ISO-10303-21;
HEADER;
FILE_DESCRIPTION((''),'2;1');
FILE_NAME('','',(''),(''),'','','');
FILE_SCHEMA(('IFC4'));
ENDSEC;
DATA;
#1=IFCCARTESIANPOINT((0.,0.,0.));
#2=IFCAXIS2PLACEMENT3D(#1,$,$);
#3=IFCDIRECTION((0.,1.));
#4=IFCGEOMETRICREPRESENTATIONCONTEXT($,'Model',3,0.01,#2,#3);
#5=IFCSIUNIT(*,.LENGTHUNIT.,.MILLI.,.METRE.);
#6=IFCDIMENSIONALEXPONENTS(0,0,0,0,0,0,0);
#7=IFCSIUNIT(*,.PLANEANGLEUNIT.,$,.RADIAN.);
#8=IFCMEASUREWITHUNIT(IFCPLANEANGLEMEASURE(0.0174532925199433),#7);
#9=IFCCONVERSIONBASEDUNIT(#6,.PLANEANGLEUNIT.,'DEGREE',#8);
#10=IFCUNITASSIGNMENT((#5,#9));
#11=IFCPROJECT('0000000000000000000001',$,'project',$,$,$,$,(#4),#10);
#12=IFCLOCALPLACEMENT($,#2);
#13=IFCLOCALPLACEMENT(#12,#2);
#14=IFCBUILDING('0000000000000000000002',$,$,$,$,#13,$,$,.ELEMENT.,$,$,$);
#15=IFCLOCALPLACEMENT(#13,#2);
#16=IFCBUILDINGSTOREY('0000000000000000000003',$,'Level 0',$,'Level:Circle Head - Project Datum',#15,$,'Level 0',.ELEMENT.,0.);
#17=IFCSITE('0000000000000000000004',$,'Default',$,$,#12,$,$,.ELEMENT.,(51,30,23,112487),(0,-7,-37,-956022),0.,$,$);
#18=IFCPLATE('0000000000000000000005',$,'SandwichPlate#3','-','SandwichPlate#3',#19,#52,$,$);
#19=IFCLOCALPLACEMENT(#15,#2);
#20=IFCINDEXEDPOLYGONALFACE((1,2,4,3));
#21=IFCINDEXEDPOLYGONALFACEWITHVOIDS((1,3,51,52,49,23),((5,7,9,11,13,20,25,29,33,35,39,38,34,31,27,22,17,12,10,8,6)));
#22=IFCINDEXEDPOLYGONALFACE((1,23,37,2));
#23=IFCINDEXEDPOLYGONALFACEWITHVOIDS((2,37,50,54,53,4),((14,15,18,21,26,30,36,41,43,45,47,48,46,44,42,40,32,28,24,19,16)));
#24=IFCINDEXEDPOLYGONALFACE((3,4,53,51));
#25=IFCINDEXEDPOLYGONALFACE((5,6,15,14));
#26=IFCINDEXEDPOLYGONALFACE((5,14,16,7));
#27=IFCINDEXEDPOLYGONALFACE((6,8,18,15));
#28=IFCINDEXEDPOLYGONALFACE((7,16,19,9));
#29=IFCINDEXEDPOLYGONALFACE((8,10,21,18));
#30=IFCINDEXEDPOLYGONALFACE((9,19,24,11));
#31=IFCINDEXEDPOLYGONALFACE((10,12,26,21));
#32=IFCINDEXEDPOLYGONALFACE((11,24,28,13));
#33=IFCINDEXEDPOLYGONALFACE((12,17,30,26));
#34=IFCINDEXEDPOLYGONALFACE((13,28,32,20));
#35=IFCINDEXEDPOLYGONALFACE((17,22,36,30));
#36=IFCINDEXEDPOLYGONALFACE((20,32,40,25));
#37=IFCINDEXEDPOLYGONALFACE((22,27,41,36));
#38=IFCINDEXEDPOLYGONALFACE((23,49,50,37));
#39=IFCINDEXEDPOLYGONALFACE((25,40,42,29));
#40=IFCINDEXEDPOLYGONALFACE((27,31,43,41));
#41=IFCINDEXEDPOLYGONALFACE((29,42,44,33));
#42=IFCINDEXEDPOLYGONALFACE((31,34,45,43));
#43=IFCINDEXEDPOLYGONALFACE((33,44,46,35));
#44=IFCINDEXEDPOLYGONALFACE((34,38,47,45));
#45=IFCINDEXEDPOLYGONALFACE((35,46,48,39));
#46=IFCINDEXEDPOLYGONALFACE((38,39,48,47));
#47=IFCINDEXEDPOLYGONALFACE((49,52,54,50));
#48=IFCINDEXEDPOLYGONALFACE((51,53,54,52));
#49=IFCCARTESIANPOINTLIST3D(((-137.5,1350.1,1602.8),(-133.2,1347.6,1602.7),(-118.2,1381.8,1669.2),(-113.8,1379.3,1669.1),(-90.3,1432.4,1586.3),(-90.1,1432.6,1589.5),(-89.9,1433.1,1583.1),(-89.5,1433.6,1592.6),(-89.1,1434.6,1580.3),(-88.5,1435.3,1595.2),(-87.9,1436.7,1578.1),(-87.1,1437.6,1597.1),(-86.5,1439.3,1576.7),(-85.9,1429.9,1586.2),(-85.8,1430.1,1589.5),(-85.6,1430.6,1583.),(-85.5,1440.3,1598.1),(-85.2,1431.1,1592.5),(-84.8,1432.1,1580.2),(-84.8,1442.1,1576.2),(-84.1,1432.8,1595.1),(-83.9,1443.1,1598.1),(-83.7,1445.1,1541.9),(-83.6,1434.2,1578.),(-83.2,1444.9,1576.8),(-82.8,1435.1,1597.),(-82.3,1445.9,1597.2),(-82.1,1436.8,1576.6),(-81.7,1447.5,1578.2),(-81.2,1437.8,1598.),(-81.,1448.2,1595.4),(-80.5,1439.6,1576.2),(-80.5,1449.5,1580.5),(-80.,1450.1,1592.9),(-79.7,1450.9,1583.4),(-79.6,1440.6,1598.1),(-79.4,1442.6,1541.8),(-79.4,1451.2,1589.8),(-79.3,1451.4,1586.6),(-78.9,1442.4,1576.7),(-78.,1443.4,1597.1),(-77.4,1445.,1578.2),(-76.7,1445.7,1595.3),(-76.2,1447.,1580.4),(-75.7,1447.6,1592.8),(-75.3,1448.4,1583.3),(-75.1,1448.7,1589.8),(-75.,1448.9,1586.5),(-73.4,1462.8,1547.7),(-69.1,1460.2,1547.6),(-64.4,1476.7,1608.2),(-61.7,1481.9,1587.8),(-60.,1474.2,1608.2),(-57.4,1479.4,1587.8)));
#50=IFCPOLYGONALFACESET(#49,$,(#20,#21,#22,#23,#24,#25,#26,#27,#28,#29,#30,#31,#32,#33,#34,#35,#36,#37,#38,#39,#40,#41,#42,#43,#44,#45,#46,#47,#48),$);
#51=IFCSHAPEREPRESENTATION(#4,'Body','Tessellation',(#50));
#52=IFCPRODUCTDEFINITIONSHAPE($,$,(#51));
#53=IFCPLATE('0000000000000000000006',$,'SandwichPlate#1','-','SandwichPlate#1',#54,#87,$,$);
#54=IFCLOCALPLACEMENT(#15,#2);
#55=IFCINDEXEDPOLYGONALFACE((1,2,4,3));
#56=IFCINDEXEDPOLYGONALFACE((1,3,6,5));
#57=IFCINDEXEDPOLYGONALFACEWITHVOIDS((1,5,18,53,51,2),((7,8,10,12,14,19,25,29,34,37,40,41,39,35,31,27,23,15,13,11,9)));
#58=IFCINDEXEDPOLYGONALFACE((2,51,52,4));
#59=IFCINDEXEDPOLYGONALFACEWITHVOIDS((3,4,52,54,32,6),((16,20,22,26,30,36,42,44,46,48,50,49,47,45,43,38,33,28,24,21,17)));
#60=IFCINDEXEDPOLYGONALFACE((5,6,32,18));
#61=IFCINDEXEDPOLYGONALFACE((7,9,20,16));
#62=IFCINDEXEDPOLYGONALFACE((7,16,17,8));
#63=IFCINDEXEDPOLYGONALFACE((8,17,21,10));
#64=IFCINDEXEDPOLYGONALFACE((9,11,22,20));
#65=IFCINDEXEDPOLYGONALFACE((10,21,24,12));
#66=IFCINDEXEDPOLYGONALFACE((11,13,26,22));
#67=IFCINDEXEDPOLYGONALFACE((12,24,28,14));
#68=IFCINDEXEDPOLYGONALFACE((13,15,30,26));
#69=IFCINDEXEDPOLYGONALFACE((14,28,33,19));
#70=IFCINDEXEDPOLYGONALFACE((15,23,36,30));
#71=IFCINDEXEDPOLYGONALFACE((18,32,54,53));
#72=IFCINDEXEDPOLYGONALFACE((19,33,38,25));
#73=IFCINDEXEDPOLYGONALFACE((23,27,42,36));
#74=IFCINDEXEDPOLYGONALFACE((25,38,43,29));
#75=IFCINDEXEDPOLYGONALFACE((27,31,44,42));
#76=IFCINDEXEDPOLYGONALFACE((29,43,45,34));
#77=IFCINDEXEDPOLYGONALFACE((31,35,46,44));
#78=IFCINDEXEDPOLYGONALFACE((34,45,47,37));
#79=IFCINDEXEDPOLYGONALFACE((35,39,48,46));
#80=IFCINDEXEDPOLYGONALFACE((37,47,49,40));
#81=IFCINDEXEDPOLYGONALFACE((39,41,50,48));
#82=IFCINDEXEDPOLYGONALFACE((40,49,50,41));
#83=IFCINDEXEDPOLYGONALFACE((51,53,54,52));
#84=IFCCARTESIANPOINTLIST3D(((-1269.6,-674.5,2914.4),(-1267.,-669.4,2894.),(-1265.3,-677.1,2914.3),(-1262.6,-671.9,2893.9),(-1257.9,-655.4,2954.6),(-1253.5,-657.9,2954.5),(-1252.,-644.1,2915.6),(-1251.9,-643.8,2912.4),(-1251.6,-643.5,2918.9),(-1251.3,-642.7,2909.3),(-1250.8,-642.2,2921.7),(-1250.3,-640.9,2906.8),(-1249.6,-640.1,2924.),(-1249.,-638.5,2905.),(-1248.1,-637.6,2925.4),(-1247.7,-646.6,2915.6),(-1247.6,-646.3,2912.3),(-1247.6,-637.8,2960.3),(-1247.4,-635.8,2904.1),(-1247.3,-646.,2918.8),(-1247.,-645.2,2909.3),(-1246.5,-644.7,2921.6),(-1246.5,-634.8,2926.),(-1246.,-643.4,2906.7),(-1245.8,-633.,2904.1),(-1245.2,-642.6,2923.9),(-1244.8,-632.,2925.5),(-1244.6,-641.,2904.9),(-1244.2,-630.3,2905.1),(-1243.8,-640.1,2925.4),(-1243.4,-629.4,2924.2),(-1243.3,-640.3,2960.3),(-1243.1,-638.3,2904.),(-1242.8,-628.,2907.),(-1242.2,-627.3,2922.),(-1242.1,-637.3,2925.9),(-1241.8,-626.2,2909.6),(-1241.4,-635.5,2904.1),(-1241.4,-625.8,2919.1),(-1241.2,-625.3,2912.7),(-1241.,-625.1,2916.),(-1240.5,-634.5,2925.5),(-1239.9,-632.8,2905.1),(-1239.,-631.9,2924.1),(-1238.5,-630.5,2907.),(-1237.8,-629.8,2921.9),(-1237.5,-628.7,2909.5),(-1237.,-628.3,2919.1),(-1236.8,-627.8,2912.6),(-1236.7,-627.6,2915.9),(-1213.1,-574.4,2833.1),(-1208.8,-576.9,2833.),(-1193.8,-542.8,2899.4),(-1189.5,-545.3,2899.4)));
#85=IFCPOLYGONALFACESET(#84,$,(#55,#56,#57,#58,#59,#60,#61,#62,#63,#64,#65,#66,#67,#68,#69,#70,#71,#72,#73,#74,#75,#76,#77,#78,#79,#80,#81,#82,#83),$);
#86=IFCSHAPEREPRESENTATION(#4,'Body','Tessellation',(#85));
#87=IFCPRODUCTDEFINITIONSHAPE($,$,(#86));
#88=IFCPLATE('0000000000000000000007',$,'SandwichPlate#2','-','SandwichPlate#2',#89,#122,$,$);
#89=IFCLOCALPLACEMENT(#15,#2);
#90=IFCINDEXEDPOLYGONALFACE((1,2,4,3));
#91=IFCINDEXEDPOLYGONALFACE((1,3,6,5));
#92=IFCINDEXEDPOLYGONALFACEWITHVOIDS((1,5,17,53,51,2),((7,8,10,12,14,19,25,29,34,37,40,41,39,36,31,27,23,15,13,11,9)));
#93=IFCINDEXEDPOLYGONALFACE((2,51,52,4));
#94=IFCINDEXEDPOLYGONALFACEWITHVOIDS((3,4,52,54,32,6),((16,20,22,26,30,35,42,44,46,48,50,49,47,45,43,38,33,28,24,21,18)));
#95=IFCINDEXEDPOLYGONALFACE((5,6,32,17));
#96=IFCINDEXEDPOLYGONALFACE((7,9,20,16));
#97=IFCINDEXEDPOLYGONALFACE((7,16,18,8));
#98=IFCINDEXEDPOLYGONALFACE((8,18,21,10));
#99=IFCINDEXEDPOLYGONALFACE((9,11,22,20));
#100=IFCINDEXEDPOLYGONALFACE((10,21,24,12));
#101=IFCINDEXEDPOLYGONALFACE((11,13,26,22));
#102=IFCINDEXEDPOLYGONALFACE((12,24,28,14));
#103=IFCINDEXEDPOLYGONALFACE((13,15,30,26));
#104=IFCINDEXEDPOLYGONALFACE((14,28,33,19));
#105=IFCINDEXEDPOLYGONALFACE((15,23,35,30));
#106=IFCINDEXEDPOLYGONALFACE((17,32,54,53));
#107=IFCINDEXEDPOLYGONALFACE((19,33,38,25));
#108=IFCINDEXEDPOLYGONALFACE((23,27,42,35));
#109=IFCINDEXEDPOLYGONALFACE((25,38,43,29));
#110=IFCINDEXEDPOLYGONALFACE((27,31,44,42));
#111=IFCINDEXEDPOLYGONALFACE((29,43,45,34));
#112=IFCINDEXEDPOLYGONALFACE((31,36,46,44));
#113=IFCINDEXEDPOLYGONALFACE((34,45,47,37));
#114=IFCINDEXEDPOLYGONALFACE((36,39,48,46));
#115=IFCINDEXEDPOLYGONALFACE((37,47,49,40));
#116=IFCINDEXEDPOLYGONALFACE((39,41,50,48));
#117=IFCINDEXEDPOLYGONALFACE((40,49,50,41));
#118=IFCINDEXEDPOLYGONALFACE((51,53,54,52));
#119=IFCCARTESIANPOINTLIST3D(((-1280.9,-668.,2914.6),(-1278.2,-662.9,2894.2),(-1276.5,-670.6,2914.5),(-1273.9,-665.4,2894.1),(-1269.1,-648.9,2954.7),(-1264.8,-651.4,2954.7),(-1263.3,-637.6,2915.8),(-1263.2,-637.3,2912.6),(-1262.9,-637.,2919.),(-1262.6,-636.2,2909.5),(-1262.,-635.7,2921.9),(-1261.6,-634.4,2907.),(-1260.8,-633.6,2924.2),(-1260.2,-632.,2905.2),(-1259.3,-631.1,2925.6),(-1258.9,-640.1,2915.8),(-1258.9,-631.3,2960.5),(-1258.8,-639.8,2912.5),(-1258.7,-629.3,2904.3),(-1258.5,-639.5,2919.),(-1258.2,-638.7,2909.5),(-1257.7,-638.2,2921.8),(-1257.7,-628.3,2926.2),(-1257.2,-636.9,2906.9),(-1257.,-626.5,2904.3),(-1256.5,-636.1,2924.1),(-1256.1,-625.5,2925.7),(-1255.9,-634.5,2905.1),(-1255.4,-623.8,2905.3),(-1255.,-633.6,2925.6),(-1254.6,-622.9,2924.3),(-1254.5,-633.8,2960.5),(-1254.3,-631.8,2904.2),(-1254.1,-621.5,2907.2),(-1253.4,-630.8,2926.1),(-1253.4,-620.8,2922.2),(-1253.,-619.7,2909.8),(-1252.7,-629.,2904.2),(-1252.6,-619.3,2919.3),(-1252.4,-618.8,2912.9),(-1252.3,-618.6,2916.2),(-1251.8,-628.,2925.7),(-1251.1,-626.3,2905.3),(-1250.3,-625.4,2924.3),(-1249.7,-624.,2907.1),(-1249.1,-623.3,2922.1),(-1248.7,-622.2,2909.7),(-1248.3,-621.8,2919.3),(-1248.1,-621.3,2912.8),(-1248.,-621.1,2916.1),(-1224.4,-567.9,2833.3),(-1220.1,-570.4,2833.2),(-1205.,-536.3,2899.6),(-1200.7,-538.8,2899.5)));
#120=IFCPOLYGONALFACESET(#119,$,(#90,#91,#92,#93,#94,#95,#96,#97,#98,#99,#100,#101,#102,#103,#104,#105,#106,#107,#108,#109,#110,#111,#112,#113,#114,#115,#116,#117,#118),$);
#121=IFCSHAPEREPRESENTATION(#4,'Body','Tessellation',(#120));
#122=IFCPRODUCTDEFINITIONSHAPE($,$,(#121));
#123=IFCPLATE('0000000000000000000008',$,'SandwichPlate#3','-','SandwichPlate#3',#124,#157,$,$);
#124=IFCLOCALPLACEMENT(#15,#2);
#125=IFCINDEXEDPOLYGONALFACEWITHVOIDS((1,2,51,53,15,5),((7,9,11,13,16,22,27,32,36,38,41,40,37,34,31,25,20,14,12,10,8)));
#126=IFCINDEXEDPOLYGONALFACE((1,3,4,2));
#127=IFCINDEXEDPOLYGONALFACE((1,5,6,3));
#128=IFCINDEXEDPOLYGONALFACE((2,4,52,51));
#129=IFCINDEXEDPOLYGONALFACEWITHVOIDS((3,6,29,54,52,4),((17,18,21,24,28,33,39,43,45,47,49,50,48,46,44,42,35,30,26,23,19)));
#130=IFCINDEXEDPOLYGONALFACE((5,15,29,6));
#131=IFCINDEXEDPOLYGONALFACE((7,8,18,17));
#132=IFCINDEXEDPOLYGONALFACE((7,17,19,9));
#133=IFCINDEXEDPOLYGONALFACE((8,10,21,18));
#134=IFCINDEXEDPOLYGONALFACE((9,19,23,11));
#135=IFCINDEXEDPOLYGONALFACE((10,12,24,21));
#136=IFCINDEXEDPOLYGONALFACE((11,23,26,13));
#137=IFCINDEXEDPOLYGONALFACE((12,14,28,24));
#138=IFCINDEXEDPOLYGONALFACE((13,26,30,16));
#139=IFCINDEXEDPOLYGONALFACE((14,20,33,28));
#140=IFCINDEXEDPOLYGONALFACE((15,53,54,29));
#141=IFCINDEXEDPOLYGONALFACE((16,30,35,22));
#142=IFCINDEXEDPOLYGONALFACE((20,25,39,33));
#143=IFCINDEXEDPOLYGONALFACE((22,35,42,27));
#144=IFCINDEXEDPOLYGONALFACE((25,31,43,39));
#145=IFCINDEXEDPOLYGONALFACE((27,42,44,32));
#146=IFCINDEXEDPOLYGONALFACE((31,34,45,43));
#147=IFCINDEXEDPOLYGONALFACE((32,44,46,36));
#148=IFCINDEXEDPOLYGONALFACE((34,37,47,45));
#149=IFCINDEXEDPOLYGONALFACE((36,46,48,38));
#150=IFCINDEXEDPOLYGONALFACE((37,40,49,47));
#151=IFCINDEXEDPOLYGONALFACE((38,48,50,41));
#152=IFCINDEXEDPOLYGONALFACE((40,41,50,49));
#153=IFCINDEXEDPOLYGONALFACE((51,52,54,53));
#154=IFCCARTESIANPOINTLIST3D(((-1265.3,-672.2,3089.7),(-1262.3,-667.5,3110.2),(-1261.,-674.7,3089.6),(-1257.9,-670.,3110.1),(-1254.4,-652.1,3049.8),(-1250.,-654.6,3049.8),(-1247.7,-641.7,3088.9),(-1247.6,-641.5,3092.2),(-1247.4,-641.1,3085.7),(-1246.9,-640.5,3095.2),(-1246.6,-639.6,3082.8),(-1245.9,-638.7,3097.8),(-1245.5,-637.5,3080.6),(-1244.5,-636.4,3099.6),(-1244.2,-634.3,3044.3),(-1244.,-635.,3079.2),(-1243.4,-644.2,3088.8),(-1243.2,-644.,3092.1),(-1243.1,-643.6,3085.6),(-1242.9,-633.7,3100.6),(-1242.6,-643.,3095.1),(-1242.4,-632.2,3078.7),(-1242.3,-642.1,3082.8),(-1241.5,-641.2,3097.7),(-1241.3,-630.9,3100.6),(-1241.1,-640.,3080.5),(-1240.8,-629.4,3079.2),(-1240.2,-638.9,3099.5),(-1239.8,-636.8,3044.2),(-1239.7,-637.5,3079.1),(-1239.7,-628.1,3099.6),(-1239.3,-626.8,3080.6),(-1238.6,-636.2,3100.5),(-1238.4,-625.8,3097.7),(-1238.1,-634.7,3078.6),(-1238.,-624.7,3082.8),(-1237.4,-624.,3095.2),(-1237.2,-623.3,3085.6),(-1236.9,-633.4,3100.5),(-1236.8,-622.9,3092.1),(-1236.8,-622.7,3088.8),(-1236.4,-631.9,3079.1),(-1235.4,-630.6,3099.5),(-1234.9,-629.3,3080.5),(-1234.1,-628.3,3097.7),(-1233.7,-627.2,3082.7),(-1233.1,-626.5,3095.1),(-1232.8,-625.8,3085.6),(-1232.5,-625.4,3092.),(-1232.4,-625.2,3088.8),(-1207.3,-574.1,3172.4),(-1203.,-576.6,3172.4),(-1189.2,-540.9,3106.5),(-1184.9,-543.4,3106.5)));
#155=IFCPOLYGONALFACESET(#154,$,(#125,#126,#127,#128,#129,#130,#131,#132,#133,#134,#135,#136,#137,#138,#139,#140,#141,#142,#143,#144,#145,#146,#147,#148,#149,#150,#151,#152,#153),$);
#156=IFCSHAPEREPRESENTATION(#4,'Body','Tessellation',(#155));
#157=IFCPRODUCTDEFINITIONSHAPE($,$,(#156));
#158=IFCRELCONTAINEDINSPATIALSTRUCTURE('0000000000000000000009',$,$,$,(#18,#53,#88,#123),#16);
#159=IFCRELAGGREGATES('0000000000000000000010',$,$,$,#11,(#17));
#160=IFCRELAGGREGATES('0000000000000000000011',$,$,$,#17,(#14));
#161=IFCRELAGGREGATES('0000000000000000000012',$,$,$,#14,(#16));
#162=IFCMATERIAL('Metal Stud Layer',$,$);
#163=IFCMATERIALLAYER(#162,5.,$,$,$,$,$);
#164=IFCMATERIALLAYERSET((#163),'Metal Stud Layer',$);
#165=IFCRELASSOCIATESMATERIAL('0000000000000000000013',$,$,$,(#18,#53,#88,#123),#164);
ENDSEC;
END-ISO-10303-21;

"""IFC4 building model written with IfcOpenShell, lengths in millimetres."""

from ifc_helpers import new_model, entity, si_unit, converted_unit, direction, frame, origin, origin_with_axes, origin_2d_with_axis, place, context, project, spatial, polyline, circle, outline, extrude, material, layer, layer_set, element, save


model = new_model("IFC4")

# Units and contexts
model_context = context("Model", 3, precision=0.01, world=origin(), true_north=direction((0.0, 1.0)))
ifc_project = project(units=[si_unit("LENGTHUNIT", "METRE", prefix="MILLI"), converted_unit("PLANEANGLEUNIT", "DEGREE", entity("IfcPlaneAngleMeasure", 0.0174532925199433), si_unit("PLANEANGLEUNIT", "RADIAN"), dimensions=[0, 0, 0, 0, 0, 0, 0])], contexts=[model_context])

# Site, building, storey
site_placement = place(None, origin())
site = spatial("IfcSite", under=ifc_project, at=site_placement, Name="Default", CompositionType="ELEMENT", RefLatitude=(51, 30, 23, 112487), RefLongitude=(0, -7, -37, -956022), RefElevation=0.0)
building_placement = place(site_placement, origin())
building = spatial("IfcBuilding", under=site, at=building_placement, CompositionType="ELEMENT")
storey_placement = place(building_placement, origin())
storey = spatial("IfcBuildingStorey", under=building, at=storey_placement, Name="Level 0", ObjectType="Level:Circle Head - Project Datum", LongName="Level 0", CompositionType="ELEMENT", Elevation=0.0)

# Plates, openings
ifc_material = material(Name="Metal Stud Layer")
ifc_layer_1 = layer(ifc_material, 5.0)
ifc_layer_set_1 = layer_set([ifc_layer_1], Name="Metal Stud Layer")
plate_1_placement = place(storey_placement, frame((-77.2, 1456.5, 1534.6), z_axis=(0.865935, -0.499948, -0.014432), x_axis=(0.254617, 0.415806, 0.873084)))
plate_1 = element("IfcPlate", 1, at=plate_1_placement, inside=storey, material=ifc_layer_set_1, Name="SandwichPlate#3", Description="-", ObjectType="SandwichPlate#3", context=model_context, shape_type="SweptSolid", body=[
    extrude(outline(polyline([(0.0, 0.0), (76.0, 0.0), (76.0, 140.0), (0.0, 140.0), (0.0, 0.0)])), origin_with_axes(), (0.0, 0.0, 1.0), 5.0),
])
opening_1_placement = place(plate_1_placement, frame((0.0, 0.0, 0.0), z_axis=(0.0, 0.0, 1.0), x_axis=(1.0, 0.0, 0.0)))
element("IfcOpeningElement", 2, at=opening_1_placement, cuts=plate_1, ObjectType="Opening", context=model_context, shape_type="SweptSolid", body=[
    extrude(outline(polyline([(0.0, 0.0), (15.0, 0.0), (0.0, 15.0), (0.0, 0.0)])), origin(), (0.0, 0.0, 1.0), 5.0),
])
opening_2_placement = place(plate_1_placement, frame((0.0, 0.0, 0.0), z_axis=(0.0, 0.0, 1.0), x_axis=(1.0, 0.0, 0.0)))
element("IfcOpeningElement", 3, at=opening_2_placement, cuts=plate_1, ObjectType="Opening", context=model_context, shape_type="SweptSolid", body=[
    extrude(outline(polyline([(76.0, 0.0), (76.0, 15.0), (61.0, 0.0), (76.0, 0.0)])), origin(), (0.0, 0.0, 1.0), 5.0),
])
opening_3_placement = place(plate_1_placement, frame((38.0, 40.0, -0.5), z_axis=(0.0, 0.0, 1.0), x_axis=(0.0, 1.0, 0.0)))
element("IfcOpeningElement", 4, at=opening_3_placement, cuts=plate_1, ObjectType="Opening", context=model_context, shape_type="SweptSolid", body=[
    extrude(circle(Radius=11.0, at=origin_2d_with_axis()), origin(), (0.0, 0.0, 1.0), 6.0),
])
plate_2_placement = place(storey_placement, frame((-1269.1, -683.3, 2901.2), z_axis=(-0.865935, 0.499948, 0.014432), x_axis=(0.254617, 0.415806, 0.873084)))
plate_2 = element("IfcPlate", 5, at=plate_2_placement, inside=storey, material=ifc_layer_set_1, Name="SandwichPlate#1", Description="-", ObjectType="SandwichPlate#1", context=model_context, shape_type="SweptSolid", body=[
    extrude(outline(polyline([(0.0, 0.0), (76.0, 0.0), (76.0, 140.0), (0.0, 140.0), (0.0, 0.0)])), origin_with_axes(), (0.0, 0.0, 1.0), 5.0),
])
opening_4_placement = place(plate_2_placement, frame((0.0, 0.0, 0.0), z_axis=(0.0, 0.0, 1.0), x_axis=(1.0, 0.0, 0.0)))
element("IfcOpeningElement", 6, at=opening_4_placement, cuts=plate_2, ObjectType="Opening", context=model_context, shape_type="SweptSolid", body=[
    extrude(outline(polyline([(0.0, 0.0), (15.0, 0.0), (0.0, 15.0), (0.0, 0.0)])), origin(), (0.0, 0.0, 1.0), 5.0),
])
opening_5_placement = place(plate_2_placement, frame((0.0, 0.0, 0.0), z_axis=(0.0, 0.0, 1.0), x_axis=(1.0, 0.0, 0.0)))
element("IfcOpeningElement", 7, at=opening_5_placement, cuts=plate_2, ObjectType="Opening", context=model_context, shape_type="SweptSolid", body=[
    extrude(outline(polyline([(76.0, 0.0), (76.0, 15.0), (61.0, 0.0), (76.0, 0.0)])), origin(), (0.0, 0.0, 1.0), 5.0),
])
opening_6_placement = place(plate_2_placement, frame((38.0, 40.0, -0.5), z_axis=(0.0, 0.0, 1.0), x_axis=(0.0, 1.0, 0.0)))
element("IfcOpeningElement", 8, at=opening_6_placement, cuts=plate_2, ObjectType="Opening", context=model_context, shape_type="SweptSolid", body=[
    extrude(circle(Radius=11.0, at=origin_2d_with_axis()), origin(), (0.0, 0.0, 1.0), 6.0),
])
plate_3_placement = place(storey_placement, frame((-1280.3, -676.8, 2901.4), z_axis=(-0.865935, 0.499948, 0.014432), x_axis=(0.254617, 0.415806, 0.873084)))
plate_3 = element("IfcPlate", 9, at=plate_3_placement, inside=storey, material=ifc_layer_set_1, Name="SandwichPlate#2", Description="-", ObjectType="SandwichPlate#2", context=model_context, shape_type="SweptSolid", body=[
    extrude(outline(polyline([(0.0, 0.0), (76.0, 0.0), (76.0, 140.0), (0.0, 140.0), (0.0, 0.0)])), origin_with_axes(), (0.0, 0.0, 1.0), 5.0),
])
opening_7_placement = place(plate_3_placement, frame((0.0, 0.0, 0.0), z_axis=(0.0, 0.0, 1.0), x_axis=(1.0, 0.0, 0.0)))
element("IfcOpeningElement", 10, at=opening_7_placement, cuts=plate_3, ObjectType="Opening", context=model_context, shape_type="SweptSolid", body=[
    extrude(outline(polyline([(0.0, 0.0), (15.0, 0.0), (0.0, 15.0), (0.0, 0.0)])), origin(), (0.0, 0.0, 1.0), 5.0),
])
opening_8_placement = place(plate_3_placement, frame((0.0, 0.0, 0.0), z_axis=(0.0, 0.0, 1.0), x_axis=(1.0, 0.0, 0.0)))
element("IfcOpeningElement", 11, at=opening_8_placement, cuts=plate_3, ObjectType="Opening", context=model_context, shape_type="SweptSolid", body=[
    extrude(outline(polyline([(76.0, 0.0), (76.0, 15.0), (61.0, 0.0), (76.0, 0.0)])), origin(), (0.0, 0.0, 1.0), 5.0),
])
opening_9_placement = place(plate_3_placement, frame((38.0, 40.0, -0.5), z_axis=(0.0, 0.0, 1.0), x_axis=(0.0, 1.0, 0.0)))
element("IfcOpeningElement", 12, at=opening_9_placement, cuts=plate_3, ObjectType="Opening", context=model_context, shape_type="SweptSolid", body=[
    extrude(circle(Radius=11.0, at=origin_2d_with_axis()), origin(), (0.0, 0.0, 1.0), 6.0),
])
plate_4_placement = place(storey_placement, frame((-1246.4, -648.0, 3036.7), z_axis=(-0.865935, 0.499948, 0.014432), x_axis=(-0.238139, -0.437501, 0.867112)))
plate_4 = element("IfcPlate", 13, at=plate_4_placement, inside=storey, material=ifc_layer_set_1, Name="SandwichPlate#3", Description="-", ObjectType="SandwichPlate#3", context=model_context, shape_type="SweptSolid", body=[
    extrude(outline(polyline([(0.0, 0.0), (76.0, 0.0), (76.0, 140.0), (0.0, 140.0), (0.0, 0.0)])), origin_with_axes(), (0.0, 0.0, 1.0), 5.0),
])
opening_10_placement = place(plate_4_placement, frame((0.0, 0.0, 0.0), z_axis=(0.0, 0.0, 1.0), x_axis=(1.0, 0.0, 0.0)))
element("IfcOpeningElement", 14, at=opening_10_placement, cuts=plate_4, ObjectType="Opening", context=model_context, shape_type="SweptSolid", body=[
    extrude(outline(polyline([(0.0, 0.0), (15.0, 0.0), (0.0, 15.0), (0.0, 0.0)])), origin(), (0.0, 0.0, 1.0), 5.0),
])
opening_11_placement = place(plate_4_placement, frame((0.0, 0.0, 0.0), z_axis=(0.0, 0.0, 1.0), x_axis=(1.0, 0.0, 0.0)))
element("IfcOpeningElement", 15, at=opening_11_placement, cuts=plate_4, ObjectType="Opening", context=model_context, shape_type="SweptSolid", body=[
    extrude(outline(polyline([(76.0, 0.0), (76.0, 15.0), (61.0, 0.0), (76.0, 0.0)])), origin(), (0.0, 0.0, 1.0), 5.0),
])
opening_12_placement = place(plate_4_placement, frame((38.0, 40.0, -0.5), z_axis=(0.0, 0.0, 1.0), x_axis=(0.0, 1.0, 0.0)))
element("IfcOpeningElement", 16, at=opening_12_placement, cuts=plate_4, ObjectType="Opening", context=model_context, shape_type="SweptSolid", body=[
    extrude(circle(Radius=11.0, at=origin_2d_with_axis()), origin(), (0.0, 0.0, 1.0), 6.0),
])

save(model, "model.ifc")
